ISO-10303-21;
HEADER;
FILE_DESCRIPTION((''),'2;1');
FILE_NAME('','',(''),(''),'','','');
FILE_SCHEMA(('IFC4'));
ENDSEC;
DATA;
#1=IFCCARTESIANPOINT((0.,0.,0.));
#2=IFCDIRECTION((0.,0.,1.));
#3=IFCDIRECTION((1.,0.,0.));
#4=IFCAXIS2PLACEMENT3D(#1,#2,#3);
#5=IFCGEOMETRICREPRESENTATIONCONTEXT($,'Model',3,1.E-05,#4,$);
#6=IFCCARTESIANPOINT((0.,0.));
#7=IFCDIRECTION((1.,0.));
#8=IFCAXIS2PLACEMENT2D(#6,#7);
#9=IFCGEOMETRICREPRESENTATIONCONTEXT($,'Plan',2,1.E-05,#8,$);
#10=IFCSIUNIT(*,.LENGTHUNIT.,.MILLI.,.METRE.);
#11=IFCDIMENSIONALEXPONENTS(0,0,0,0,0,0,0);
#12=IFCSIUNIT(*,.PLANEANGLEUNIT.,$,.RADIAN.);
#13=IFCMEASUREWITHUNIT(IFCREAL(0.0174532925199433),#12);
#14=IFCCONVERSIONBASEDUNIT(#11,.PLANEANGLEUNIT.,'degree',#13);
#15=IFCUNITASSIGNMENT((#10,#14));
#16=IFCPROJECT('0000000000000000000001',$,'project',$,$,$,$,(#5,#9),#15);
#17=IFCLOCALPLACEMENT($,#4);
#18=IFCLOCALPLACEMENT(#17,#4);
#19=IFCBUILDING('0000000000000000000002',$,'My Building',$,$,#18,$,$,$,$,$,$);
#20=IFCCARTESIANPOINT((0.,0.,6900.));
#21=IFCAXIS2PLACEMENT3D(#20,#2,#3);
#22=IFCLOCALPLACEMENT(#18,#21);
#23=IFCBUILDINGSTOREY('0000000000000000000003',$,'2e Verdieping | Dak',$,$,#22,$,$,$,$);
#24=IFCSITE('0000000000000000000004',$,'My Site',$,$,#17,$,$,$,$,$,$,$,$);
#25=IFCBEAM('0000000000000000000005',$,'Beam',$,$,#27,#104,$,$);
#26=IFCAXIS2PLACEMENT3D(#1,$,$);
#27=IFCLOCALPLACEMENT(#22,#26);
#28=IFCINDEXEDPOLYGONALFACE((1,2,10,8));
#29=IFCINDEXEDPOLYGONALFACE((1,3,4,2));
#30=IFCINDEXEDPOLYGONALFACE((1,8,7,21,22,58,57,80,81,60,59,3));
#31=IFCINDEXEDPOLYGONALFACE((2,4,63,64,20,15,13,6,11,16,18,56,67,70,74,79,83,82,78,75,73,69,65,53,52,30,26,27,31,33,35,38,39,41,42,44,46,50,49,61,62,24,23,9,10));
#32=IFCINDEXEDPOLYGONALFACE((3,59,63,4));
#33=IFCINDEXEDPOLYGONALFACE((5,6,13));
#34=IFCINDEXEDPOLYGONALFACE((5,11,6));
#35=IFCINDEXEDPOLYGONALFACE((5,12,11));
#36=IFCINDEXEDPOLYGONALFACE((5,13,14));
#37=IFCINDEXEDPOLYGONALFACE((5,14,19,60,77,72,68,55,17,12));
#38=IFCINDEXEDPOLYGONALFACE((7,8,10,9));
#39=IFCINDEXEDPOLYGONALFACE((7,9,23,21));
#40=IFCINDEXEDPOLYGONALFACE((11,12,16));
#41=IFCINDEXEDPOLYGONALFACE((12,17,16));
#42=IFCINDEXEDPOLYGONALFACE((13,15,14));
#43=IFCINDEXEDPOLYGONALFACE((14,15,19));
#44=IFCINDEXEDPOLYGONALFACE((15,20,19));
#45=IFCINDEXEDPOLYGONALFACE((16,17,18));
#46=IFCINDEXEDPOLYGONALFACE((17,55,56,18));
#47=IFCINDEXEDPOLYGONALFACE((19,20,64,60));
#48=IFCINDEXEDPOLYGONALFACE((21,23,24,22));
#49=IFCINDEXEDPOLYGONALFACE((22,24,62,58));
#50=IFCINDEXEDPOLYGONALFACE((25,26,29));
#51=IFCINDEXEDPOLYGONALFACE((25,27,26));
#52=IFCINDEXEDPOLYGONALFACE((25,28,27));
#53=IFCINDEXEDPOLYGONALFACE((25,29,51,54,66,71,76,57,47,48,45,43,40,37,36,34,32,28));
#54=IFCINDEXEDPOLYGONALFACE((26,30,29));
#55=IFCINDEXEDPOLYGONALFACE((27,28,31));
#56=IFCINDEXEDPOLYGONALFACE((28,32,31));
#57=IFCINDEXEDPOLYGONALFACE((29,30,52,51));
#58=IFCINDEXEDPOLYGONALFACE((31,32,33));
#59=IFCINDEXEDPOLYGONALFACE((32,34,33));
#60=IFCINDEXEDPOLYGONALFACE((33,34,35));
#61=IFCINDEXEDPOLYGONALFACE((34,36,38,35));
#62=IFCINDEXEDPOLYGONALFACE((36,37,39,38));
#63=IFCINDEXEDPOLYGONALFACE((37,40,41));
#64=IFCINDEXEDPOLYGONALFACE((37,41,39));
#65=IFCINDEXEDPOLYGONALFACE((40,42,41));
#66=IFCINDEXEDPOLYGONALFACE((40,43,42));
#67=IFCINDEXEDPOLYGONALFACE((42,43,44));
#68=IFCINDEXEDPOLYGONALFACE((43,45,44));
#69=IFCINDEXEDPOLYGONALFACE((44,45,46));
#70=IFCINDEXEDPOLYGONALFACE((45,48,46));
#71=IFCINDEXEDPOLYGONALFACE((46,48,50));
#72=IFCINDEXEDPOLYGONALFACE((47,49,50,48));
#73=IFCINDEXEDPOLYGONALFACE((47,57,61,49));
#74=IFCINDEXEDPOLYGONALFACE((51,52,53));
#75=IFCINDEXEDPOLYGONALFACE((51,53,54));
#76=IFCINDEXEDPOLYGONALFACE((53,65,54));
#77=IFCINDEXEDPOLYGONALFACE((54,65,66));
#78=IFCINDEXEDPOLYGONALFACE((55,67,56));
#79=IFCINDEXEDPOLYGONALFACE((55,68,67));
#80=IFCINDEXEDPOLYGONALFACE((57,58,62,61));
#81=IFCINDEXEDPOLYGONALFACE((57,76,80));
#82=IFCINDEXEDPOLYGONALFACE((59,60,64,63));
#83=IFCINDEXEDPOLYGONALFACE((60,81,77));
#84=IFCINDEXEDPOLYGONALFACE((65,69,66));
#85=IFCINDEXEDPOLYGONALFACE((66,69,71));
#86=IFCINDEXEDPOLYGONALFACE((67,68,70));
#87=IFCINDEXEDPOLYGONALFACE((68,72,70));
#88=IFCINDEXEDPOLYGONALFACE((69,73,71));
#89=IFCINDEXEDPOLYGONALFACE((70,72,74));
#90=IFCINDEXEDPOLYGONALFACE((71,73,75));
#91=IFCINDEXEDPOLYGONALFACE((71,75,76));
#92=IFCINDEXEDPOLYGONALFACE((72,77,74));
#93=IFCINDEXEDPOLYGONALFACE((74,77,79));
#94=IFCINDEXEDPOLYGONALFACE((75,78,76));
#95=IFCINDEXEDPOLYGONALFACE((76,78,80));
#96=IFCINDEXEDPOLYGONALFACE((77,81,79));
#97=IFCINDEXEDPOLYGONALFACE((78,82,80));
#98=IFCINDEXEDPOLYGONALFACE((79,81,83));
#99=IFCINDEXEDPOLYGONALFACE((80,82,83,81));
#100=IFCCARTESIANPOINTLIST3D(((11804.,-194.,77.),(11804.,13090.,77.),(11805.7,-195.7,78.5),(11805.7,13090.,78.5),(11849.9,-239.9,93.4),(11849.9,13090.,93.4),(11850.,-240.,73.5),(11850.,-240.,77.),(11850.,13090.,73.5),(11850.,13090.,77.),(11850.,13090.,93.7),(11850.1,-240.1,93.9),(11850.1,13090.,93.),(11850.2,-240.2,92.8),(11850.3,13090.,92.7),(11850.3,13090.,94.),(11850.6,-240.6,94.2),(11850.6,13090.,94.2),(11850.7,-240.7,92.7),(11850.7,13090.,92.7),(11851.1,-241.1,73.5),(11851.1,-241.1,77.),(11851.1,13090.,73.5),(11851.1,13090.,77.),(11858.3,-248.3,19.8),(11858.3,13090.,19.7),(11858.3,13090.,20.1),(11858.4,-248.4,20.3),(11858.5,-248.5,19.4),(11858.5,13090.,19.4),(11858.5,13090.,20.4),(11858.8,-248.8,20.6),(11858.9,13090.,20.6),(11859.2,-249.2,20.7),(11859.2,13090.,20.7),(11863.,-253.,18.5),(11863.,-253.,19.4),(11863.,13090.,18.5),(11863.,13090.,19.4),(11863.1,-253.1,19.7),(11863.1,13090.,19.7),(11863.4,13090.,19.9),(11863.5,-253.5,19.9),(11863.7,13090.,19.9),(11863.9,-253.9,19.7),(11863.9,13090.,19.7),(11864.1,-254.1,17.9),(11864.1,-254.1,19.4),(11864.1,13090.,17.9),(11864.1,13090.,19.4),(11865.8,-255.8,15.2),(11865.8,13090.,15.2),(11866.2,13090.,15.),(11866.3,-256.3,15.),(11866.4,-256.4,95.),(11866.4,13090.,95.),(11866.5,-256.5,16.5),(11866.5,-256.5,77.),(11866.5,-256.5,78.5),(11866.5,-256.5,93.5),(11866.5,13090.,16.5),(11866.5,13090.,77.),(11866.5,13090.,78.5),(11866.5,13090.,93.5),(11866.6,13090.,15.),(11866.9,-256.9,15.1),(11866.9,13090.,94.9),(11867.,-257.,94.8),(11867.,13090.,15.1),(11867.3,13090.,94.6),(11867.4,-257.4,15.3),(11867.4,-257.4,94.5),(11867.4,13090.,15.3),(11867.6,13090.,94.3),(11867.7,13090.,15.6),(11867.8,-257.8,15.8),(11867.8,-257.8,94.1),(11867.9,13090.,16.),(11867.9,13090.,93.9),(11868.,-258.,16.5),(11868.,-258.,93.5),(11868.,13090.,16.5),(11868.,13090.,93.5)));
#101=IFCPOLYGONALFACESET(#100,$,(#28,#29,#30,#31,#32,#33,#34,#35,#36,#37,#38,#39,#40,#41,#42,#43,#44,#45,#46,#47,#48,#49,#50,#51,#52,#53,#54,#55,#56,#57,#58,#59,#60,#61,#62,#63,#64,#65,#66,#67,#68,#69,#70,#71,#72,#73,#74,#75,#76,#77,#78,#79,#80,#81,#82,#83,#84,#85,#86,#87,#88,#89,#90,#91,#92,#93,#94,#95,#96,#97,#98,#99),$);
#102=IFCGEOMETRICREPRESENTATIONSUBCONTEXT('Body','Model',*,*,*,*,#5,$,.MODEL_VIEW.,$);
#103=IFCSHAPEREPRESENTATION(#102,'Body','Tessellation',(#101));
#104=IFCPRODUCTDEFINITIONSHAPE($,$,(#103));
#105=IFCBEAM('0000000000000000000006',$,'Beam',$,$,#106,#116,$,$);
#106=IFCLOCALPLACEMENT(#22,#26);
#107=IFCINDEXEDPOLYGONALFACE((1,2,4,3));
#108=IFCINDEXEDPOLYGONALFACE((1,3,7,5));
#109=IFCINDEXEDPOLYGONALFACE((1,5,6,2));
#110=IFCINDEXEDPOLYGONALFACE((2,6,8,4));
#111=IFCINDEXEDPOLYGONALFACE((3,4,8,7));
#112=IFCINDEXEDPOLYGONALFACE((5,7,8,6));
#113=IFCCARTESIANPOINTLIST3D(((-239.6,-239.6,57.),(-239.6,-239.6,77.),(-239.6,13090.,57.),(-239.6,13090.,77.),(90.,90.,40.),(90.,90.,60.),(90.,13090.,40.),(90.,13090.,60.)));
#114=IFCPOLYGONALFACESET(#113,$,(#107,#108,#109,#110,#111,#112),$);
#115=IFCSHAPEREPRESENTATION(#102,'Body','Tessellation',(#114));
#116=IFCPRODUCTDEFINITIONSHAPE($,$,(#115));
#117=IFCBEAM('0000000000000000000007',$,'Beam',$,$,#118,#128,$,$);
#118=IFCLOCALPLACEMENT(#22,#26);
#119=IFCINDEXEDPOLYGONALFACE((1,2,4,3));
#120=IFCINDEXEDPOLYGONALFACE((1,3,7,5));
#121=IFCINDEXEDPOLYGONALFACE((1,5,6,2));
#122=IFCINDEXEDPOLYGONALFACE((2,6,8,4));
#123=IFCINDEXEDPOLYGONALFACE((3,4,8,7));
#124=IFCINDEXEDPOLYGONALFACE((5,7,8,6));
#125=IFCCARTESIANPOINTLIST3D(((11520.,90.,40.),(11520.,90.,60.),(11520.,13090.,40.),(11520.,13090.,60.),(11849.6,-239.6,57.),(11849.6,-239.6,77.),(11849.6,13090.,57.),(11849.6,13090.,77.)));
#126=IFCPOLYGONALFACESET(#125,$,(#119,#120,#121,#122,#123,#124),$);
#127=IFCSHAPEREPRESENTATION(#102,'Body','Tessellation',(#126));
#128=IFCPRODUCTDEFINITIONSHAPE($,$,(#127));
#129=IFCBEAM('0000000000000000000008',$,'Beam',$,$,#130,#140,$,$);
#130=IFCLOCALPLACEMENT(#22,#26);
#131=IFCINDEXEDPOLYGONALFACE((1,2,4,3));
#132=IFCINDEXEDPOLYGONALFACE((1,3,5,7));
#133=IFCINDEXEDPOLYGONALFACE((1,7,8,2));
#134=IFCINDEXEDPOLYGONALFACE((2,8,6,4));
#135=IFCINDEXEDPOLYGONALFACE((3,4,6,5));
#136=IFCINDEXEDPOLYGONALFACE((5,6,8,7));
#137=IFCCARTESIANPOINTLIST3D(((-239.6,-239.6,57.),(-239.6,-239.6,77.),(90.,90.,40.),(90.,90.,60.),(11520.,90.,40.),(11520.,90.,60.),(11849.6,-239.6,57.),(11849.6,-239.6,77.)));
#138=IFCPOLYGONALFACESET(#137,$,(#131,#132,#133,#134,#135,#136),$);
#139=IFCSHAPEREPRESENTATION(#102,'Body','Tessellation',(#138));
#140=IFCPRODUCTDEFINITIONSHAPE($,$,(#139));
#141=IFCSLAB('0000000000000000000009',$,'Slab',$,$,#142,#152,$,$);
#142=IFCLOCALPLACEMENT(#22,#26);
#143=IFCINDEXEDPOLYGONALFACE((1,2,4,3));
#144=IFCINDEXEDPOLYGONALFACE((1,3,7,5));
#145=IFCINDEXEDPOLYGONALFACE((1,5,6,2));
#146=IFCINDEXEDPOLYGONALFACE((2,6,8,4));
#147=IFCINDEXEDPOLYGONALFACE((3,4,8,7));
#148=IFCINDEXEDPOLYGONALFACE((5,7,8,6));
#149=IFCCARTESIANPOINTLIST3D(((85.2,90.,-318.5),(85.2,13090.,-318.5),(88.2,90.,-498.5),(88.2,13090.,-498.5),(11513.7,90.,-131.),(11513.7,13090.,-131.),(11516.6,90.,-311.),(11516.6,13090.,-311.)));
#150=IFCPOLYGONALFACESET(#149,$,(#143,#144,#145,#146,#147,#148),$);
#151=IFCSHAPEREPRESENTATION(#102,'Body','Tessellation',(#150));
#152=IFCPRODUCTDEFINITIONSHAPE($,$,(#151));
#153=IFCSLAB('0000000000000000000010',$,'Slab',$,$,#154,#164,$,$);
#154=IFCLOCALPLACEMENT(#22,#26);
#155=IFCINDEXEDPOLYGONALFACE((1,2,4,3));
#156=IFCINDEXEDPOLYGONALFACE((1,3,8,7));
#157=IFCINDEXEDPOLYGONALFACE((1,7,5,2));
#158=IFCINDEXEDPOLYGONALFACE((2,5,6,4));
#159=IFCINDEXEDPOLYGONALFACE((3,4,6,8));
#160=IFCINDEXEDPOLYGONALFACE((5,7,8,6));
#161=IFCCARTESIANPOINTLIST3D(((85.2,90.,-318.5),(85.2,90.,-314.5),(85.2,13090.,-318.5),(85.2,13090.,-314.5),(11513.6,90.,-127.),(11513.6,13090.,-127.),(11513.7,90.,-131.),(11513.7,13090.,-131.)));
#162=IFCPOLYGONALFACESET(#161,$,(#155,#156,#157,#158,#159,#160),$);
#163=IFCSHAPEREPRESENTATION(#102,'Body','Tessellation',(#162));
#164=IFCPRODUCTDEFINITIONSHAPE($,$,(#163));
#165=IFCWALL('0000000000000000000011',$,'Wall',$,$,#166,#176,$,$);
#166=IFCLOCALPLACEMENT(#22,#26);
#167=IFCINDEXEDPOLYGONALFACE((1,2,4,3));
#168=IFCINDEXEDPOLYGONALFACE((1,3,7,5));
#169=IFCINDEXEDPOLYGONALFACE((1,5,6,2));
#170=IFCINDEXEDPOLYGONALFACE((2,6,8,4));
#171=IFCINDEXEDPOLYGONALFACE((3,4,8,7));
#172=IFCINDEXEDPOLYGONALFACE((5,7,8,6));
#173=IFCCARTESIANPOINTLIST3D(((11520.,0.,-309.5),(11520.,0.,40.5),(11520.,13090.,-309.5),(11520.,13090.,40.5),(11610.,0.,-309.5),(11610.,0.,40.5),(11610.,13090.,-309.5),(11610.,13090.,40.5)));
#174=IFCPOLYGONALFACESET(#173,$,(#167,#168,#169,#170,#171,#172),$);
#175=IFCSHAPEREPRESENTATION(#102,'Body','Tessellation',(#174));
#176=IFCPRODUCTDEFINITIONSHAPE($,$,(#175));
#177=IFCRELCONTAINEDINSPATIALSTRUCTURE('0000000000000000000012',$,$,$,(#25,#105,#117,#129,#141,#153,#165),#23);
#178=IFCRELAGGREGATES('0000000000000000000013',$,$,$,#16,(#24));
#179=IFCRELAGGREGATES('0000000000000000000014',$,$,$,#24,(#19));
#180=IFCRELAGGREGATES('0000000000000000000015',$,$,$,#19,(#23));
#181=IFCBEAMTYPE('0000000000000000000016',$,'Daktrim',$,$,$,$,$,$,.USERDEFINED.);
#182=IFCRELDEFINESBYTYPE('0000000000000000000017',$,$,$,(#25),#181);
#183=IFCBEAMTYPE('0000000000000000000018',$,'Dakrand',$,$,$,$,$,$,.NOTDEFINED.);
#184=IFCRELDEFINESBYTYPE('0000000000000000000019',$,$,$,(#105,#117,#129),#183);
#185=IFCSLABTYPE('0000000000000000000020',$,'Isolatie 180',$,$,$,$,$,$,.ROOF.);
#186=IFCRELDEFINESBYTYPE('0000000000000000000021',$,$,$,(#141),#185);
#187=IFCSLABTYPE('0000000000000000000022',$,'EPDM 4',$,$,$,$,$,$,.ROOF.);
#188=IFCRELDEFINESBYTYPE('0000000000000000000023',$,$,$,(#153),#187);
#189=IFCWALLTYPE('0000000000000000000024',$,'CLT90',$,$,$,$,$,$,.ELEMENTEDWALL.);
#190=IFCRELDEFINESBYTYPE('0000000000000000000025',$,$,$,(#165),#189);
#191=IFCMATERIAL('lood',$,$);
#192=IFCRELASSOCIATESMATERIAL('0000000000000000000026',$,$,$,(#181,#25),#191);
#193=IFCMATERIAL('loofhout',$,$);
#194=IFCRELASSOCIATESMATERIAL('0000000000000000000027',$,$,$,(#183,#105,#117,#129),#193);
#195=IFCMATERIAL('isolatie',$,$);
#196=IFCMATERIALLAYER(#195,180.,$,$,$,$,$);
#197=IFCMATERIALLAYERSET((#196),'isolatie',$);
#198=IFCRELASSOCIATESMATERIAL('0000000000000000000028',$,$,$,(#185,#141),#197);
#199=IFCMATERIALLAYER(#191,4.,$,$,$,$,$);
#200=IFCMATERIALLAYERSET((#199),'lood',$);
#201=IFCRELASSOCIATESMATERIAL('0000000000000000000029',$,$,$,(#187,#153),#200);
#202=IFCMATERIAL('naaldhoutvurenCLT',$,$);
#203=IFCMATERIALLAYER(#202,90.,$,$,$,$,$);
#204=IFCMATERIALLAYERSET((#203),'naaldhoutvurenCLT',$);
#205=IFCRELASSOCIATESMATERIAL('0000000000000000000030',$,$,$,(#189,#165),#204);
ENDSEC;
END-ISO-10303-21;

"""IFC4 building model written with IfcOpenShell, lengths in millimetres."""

from ifc_helpers import new_model, entity, si_unit, converted_unit, frame, origin_with_axes, origin_2d_with_axis, place, context, subcontext, project, spatial, line, arc, indexed_curve, outline, extrude, clip, halfspace, material, layer, layer_set, layer_usage, material_profile, profile_set, profile_usage, type_object, element, save


model = new_model("IFC4")

# Units and contexts
model_context = context("Model", 3, precision=1e-05, world=origin_with_axes())
plan_context = context("Plan", 2, precision=1e-05, world=origin_2d_with_axis())
body_context = subcontext(model_context, "Body", "Model", "MODEL_VIEW")
ifc_project = project(units=[si_unit("LENGTHUNIT", "METRE", prefix="MILLI"), converted_unit("PLANEANGLEUNIT", "degree", entity("IfcReal", 0.0174532925199433), si_unit("PLANEANGLEUNIT", "RADIAN"), dimensions=[0, 0, 0, 0, 0, 0, 0])], contexts=[model_context, plan_context])

# Site, building, storey
site_placement = place(None, origin_with_axes())
site = spatial("IfcSite", under=ifc_project, at=site_placement, Name="My Site")
building_placement = place(site_placement, origin_with_axes())
building = spatial("IfcBuilding", under=site, at=building_placement, Name="My Building")
storey_placement = place(building_placement, frame((0.0, 0.0, 6900.0), z_axis=(0.0, 0.0, 1.0), x_axis=(1.0, 0.0, 0.0)))
storey = spatial("IfcBuildingStorey", under=building, at=storey_placement, Name="2e Verdieping | Dak")

# Beams
ifc_material_1 = material(Name="lood")
ifc_material_profile_1 = material_profile(ifc_material_1, outline(indexed_curve([(12.9, -58.5), (12.9, -57.6), (13.5, -57.1), (14.1, -57.6), (14.1, -59.1), (16.5, -60.5), (16.5, 0.0), (1.1, 0.0), (1.1, -3.5), (0.0, -3.5), (0.0, 0.0), (-46.0, 0.0), (-44.3, 1.5), (16.5, 1.5), (16.5, 16.5), (0.7, 15.7), (-0.1, 16.4), (0.6, 17.2), (16.4, 18.0), (17.6, 17.3), (18.0, 16.5), (18.0, -60.5), (17.2, -61.8), (15.8, -61.8), (8.5, -57.6), (8.4, -56.7), (9.2, -56.3)], segments=[line(10, 9), line(9, 8), line(8, 7), line(7, 6), line(6, 5), line(5, 4), arc(4, 3, 2), line(2, 1), line(1, 27), arc(27, 26, 25), line(25, 24), arc(24, 23, 22), line(22, 21), arc(21, 20, 19), line(19, 18), arc(18, 17, 16), line(16, 15), line(15, 14), line(14, 13), line(13, 12), line(12, 11), line(11, 10)], self_intersect=False)))
ifc_profile_set_1 = profile_set([ifc_material_profile_1], Name="lood")
beam_type_1 = type_object("IfcBeamType", Name="Daktrim", PredefinedType="USERDEFINED", material=ifc_profile_set_1)
ifc_profile_usage_1 = profile_usage(ifc_profile_set_1, cardinal=5)
beam_1_placement = place(storey_placement, frame((11850.0, 13090.0, 77.0), z_axis=(0.0, -1.0, 0.0), x_axis=(1.0, 0.0, 0.0)))
element("IfcBeam", 1, at=beam_1_placement, inside=storey, type_object=beam_type_1, material=ifc_profile_usage_1, Name="Beam", context=body_context, shape_type="Clipping", body=[
    clip(extrude(outline(indexed_curve([(12.9, -58.5), (12.9, -57.6), (13.5, -57.1), (14.1, -57.6), (14.1, -59.1), (16.5, -60.5), (16.5, 0.0), (1.1, 0.0), (1.1, -3.5), (0.0, -3.5), (0.0, 0.0), (-46.0, 0.0), (-44.3, 1.5), (16.5, 1.5), (16.5, 16.5), (0.7, 15.7), (-0.1, 16.4), (0.6, 17.2), (16.4, 18.0), (17.6, 17.3), (18.0, 16.5), (18.0, -60.5), (17.2, -61.8), (15.8, -61.8), (8.5, -57.6), (8.4, -56.7), (9.2, -56.3)], segments=[line(10, 9), line(9, 8), line(8, 7), line(7, 6), line(6, 5), line(5, 4), arc(4, 3, 2), line(2, 1), line(1, 27), arc(27, 26, 25), line(25, 24), arc(24, 23, 22), line(22, 21), arc(21, 20, 19), line(19, 18), arc(18, 17, 16), line(16, 15), line(15, 14), line(14, 13), line(13, 12), line(12, 11), line(11, 10)], self_intersect=False)), origin_with_axes(), (0.0, 0.0, 1.0), 13348.0), halfspace(frame((18.0, -6977.0, 13348.0), z_axis=(-0.707106, 0.0, 0.707107), x_axis=(0.0, 1.0, 0.0)), False)),
])
ifc_material_2 = material(Name="loofhout")
ifc_material_profile_2 = material_profile(ifc_material_2, outline(indexed_curve([(329.6, 37.0), (329.6, 17.0), (0.0, 0.0), (0.0, 20.0)], segments=[line(3, 2), line(2, 1), line(1, 4), line(4, 3)], self_intersect=False)))
ifc_profile_set_2 = profile_set([ifc_material_profile_2], Name="loofhout")
ifc_profile_usage_2 = profile_usage(ifc_profile_set_2)
beam_type_2 = type_object("IfcBeamType", Name="Dakrand", PredefinedType="NOTDEFINED", material=ifc_profile_set_2)
beam_2_placement = place(storey_placement, frame((90.0, -239.6, 40.0), z_axis=(0.0, 1.0, 0.0), x_axis=(-1.0, 0.0, 0.0)))
element("IfcBeam", 2, at=beam_2_placement, inside=storey, type_object=beam_type_2, material=ifc_profile_usage_2, Name="Beam", context=body_context, shape_type="Clipping", body=[
    clip(extrude(outline(indexed_curve([(329.6, 37.0), (329.6, 17.0), (0.0, 0.0), (0.0, 20.0)], segments=[line(3, 2), line(2, 1), line(1, 4), line(4, 3)], self_intersect=False)), origin_with_axes(), (0.0, 0.0, 1.0), 13329.6), halfspace(frame((329.6, -6940.0, 0.0), z_axis=(-0.707107, 0.0, -0.707107), x_axis=(0.0, 1.0, 0.0)), False)),
])
ifc_profile_usage_3 = profile_usage(ifc_profile_set_2)
beam_3_placement = place(storey_placement, frame((11520.0, 13090.0, 40.0), z_axis=(0.0, -1.0, 0.0), x_axis=(1.0, 0.0, 0.0)))
element("IfcBeam", 3, at=beam_3_placement, inside=storey, type_object=beam_type_2, material=ifc_profile_usage_3, Name="Beam", context=body_context, shape_type="Clipping", body=[
    clip(extrude(outline(indexed_curve([(329.6, 37.0), (329.6, 17.0), (0.0, 0.0), (0.0, 20.0)], segments=[line(3, 2), line(2, 1), line(1, 4), line(4, 3)], self_intersect=False)), origin_with_axes(), (0.0, 0.0, 1.0), 13329.6), halfspace(frame((329.6, -6940.0, 13329.6), z_axis=(-0.707106, 0.0, 0.707107), x_axis=(0.0, 1.0, 0.0)), False)),
])
ifc_profile_usage_4 = profile_usage(ifc_profile_set_2)
beam_4_placement = place(storey_placement, frame((11849.6, 90.0, 40.0), z_axis=(-1.0, 0.0, 0.0), x_axis=(0.0, -1.0, 0.0)))
element("IfcBeam", 4, at=beam_4_placement, inside=storey, type_object=beam_type_2, material=ifc_profile_usage_4, Name="Beam", context=body_context, shape_type="Clipping", body=[
    clip(clip(extrude(outline(indexed_curve([(329.6, 37.0), (329.6, 17.0), (0.0, 0.0), (0.0, 20.0)], segments=[line(3, 2), line(2, 1), line(1, 4), line(4, 3)], self_intersect=False)), origin_with_axes(), (0.0, 0.0, 1.0), 12089.1), halfspace(frame((329.6, -6940.0, 12089.1), z_axis=(-0.707107, 0.0, 0.707107), x_axis=(0.0, 1.0, 0.0)), False)), halfspace(frame((329.6, -6940.0, 0.0), z_axis=(-0.707107, 0.0, -0.707106), x_axis=(0.0, 1.0, 0.0)), False)),
])

# Slabs
ifc_material_3 = material(Name="naaldhoutvurenCLT")
ifc_material_4 = material(Name="isolatie")
ifc_layer_1 = layer(ifc_material_4, 180.0)
ifc_layer_set_1 = layer_set([ifc_layer_1], Name="isolatie")
ifc_layer_usage_1 = layer_usage(ifc_layer_set_1, "AXIS3", "POSITIVE", 0.0)
slab_type_1 = type_object("IfcSlabType", Name="Isolatie 180", PredefinedType="ROOF", material=ifc_layer_set_1)
slab_1_placement = place(storey_placement, frame((11516.6, 90.0, -311.0), z_axis=(-0.016405, 0.0, 0.999865), x_axis=(0.999865, 0.0, 0.016405)))
element("IfcSlab", 5, at=slab_1_placement, inside=storey, type_object=slab_type_1, material=ifc_layer_usage_1, Name="Slab", context=body_context, shape_type="SweptSolid", body=[
    extrude(outline(indexed_curve([(-11430.0, 0.0), (0.0, 0.0), (0.0, 13000.0), (-11430.0, 13000.0)], segments=[line(3, 2), line(2, 1), line(1, 4), line(4, 3)], self_intersect=False)), None, (0.0, 0.0, 1.0), 180.0),
])
ifc_layer_2 = layer(ifc_material_1, 4.0)
ifc_layer_set_2 = layer_set([ifc_layer_2], Name="lood")
ifc_layer_usage_2 = layer_usage(ifc_layer_set_2, "AXIS3", "POSITIVE", 0.0)
slab_type_2 = type_object("IfcSlabType", Name="EPDM 4", PredefinedType="ROOF", material=ifc_layer_set_2)
slab_2_placement = place(storey_placement, frame((11513.7, 90.0, -131.0), z_axis=(-0.016405, 0.0, 0.999865), x_axis=(0.999865, 0.0, 0.016405)))
element("IfcSlab", 6, at=slab_2_placement, inside=storey, type_object=slab_type_2, material=ifc_layer_usage_2, Name="Slab", context=body_context, shape_type="SweptSolid", body=[
    extrude(outline(indexed_curve([(0.0, 0.0), (-11430.0, 0.0), (-11430.0, 13000.0), (0.0, 13000.0)], segments=[line(3, 2), line(2, 1), line(1, 4), line(4, 3)], self_intersect=False)), None, (0.0, 0.0, 1.0), 4.0),
])

# Wall
ifc_layer_3 = layer(ifc_material_3, 90.0)
ifc_layer_set_3 = layer_set([ifc_layer_3], Name="naaldhoutvurenCLT")
ifc_layer_usage_3 = layer_usage(ifc_layer_set_3, "AXIS2", "POSITIVE", 0.0)
wall_type = type_object("IfcWallType", Name="CLT90", PredefinedType="ELEMENTEDWALL", material=ifc_layer_set_3)
wall_1_placement = place(storey_placement, frame((11610.0, 0.0, -309.5), z_axis=(0.0, 0.0, 1.0), x_axis=(0.0, 1.0, 0.0)))
element("IfcWall", 7, at=wall_1_placement, inside=storey, type_object=wall_type, material=ifc_layer_usage_3, Name="Wall", context=body_context, shape_type="SweptSolid", body=[
    extrude(outline(indexed_curve([(0.0, 0.0), (0.0, 90.0), (13090.0, 90.0), (13090.0, 0.0), (0.0, 0.0)], self_intersect=False)), origin_with_axes(), (0.0, 0.0, 1.0), 350.0),
])

save(model, "model.ifc")
